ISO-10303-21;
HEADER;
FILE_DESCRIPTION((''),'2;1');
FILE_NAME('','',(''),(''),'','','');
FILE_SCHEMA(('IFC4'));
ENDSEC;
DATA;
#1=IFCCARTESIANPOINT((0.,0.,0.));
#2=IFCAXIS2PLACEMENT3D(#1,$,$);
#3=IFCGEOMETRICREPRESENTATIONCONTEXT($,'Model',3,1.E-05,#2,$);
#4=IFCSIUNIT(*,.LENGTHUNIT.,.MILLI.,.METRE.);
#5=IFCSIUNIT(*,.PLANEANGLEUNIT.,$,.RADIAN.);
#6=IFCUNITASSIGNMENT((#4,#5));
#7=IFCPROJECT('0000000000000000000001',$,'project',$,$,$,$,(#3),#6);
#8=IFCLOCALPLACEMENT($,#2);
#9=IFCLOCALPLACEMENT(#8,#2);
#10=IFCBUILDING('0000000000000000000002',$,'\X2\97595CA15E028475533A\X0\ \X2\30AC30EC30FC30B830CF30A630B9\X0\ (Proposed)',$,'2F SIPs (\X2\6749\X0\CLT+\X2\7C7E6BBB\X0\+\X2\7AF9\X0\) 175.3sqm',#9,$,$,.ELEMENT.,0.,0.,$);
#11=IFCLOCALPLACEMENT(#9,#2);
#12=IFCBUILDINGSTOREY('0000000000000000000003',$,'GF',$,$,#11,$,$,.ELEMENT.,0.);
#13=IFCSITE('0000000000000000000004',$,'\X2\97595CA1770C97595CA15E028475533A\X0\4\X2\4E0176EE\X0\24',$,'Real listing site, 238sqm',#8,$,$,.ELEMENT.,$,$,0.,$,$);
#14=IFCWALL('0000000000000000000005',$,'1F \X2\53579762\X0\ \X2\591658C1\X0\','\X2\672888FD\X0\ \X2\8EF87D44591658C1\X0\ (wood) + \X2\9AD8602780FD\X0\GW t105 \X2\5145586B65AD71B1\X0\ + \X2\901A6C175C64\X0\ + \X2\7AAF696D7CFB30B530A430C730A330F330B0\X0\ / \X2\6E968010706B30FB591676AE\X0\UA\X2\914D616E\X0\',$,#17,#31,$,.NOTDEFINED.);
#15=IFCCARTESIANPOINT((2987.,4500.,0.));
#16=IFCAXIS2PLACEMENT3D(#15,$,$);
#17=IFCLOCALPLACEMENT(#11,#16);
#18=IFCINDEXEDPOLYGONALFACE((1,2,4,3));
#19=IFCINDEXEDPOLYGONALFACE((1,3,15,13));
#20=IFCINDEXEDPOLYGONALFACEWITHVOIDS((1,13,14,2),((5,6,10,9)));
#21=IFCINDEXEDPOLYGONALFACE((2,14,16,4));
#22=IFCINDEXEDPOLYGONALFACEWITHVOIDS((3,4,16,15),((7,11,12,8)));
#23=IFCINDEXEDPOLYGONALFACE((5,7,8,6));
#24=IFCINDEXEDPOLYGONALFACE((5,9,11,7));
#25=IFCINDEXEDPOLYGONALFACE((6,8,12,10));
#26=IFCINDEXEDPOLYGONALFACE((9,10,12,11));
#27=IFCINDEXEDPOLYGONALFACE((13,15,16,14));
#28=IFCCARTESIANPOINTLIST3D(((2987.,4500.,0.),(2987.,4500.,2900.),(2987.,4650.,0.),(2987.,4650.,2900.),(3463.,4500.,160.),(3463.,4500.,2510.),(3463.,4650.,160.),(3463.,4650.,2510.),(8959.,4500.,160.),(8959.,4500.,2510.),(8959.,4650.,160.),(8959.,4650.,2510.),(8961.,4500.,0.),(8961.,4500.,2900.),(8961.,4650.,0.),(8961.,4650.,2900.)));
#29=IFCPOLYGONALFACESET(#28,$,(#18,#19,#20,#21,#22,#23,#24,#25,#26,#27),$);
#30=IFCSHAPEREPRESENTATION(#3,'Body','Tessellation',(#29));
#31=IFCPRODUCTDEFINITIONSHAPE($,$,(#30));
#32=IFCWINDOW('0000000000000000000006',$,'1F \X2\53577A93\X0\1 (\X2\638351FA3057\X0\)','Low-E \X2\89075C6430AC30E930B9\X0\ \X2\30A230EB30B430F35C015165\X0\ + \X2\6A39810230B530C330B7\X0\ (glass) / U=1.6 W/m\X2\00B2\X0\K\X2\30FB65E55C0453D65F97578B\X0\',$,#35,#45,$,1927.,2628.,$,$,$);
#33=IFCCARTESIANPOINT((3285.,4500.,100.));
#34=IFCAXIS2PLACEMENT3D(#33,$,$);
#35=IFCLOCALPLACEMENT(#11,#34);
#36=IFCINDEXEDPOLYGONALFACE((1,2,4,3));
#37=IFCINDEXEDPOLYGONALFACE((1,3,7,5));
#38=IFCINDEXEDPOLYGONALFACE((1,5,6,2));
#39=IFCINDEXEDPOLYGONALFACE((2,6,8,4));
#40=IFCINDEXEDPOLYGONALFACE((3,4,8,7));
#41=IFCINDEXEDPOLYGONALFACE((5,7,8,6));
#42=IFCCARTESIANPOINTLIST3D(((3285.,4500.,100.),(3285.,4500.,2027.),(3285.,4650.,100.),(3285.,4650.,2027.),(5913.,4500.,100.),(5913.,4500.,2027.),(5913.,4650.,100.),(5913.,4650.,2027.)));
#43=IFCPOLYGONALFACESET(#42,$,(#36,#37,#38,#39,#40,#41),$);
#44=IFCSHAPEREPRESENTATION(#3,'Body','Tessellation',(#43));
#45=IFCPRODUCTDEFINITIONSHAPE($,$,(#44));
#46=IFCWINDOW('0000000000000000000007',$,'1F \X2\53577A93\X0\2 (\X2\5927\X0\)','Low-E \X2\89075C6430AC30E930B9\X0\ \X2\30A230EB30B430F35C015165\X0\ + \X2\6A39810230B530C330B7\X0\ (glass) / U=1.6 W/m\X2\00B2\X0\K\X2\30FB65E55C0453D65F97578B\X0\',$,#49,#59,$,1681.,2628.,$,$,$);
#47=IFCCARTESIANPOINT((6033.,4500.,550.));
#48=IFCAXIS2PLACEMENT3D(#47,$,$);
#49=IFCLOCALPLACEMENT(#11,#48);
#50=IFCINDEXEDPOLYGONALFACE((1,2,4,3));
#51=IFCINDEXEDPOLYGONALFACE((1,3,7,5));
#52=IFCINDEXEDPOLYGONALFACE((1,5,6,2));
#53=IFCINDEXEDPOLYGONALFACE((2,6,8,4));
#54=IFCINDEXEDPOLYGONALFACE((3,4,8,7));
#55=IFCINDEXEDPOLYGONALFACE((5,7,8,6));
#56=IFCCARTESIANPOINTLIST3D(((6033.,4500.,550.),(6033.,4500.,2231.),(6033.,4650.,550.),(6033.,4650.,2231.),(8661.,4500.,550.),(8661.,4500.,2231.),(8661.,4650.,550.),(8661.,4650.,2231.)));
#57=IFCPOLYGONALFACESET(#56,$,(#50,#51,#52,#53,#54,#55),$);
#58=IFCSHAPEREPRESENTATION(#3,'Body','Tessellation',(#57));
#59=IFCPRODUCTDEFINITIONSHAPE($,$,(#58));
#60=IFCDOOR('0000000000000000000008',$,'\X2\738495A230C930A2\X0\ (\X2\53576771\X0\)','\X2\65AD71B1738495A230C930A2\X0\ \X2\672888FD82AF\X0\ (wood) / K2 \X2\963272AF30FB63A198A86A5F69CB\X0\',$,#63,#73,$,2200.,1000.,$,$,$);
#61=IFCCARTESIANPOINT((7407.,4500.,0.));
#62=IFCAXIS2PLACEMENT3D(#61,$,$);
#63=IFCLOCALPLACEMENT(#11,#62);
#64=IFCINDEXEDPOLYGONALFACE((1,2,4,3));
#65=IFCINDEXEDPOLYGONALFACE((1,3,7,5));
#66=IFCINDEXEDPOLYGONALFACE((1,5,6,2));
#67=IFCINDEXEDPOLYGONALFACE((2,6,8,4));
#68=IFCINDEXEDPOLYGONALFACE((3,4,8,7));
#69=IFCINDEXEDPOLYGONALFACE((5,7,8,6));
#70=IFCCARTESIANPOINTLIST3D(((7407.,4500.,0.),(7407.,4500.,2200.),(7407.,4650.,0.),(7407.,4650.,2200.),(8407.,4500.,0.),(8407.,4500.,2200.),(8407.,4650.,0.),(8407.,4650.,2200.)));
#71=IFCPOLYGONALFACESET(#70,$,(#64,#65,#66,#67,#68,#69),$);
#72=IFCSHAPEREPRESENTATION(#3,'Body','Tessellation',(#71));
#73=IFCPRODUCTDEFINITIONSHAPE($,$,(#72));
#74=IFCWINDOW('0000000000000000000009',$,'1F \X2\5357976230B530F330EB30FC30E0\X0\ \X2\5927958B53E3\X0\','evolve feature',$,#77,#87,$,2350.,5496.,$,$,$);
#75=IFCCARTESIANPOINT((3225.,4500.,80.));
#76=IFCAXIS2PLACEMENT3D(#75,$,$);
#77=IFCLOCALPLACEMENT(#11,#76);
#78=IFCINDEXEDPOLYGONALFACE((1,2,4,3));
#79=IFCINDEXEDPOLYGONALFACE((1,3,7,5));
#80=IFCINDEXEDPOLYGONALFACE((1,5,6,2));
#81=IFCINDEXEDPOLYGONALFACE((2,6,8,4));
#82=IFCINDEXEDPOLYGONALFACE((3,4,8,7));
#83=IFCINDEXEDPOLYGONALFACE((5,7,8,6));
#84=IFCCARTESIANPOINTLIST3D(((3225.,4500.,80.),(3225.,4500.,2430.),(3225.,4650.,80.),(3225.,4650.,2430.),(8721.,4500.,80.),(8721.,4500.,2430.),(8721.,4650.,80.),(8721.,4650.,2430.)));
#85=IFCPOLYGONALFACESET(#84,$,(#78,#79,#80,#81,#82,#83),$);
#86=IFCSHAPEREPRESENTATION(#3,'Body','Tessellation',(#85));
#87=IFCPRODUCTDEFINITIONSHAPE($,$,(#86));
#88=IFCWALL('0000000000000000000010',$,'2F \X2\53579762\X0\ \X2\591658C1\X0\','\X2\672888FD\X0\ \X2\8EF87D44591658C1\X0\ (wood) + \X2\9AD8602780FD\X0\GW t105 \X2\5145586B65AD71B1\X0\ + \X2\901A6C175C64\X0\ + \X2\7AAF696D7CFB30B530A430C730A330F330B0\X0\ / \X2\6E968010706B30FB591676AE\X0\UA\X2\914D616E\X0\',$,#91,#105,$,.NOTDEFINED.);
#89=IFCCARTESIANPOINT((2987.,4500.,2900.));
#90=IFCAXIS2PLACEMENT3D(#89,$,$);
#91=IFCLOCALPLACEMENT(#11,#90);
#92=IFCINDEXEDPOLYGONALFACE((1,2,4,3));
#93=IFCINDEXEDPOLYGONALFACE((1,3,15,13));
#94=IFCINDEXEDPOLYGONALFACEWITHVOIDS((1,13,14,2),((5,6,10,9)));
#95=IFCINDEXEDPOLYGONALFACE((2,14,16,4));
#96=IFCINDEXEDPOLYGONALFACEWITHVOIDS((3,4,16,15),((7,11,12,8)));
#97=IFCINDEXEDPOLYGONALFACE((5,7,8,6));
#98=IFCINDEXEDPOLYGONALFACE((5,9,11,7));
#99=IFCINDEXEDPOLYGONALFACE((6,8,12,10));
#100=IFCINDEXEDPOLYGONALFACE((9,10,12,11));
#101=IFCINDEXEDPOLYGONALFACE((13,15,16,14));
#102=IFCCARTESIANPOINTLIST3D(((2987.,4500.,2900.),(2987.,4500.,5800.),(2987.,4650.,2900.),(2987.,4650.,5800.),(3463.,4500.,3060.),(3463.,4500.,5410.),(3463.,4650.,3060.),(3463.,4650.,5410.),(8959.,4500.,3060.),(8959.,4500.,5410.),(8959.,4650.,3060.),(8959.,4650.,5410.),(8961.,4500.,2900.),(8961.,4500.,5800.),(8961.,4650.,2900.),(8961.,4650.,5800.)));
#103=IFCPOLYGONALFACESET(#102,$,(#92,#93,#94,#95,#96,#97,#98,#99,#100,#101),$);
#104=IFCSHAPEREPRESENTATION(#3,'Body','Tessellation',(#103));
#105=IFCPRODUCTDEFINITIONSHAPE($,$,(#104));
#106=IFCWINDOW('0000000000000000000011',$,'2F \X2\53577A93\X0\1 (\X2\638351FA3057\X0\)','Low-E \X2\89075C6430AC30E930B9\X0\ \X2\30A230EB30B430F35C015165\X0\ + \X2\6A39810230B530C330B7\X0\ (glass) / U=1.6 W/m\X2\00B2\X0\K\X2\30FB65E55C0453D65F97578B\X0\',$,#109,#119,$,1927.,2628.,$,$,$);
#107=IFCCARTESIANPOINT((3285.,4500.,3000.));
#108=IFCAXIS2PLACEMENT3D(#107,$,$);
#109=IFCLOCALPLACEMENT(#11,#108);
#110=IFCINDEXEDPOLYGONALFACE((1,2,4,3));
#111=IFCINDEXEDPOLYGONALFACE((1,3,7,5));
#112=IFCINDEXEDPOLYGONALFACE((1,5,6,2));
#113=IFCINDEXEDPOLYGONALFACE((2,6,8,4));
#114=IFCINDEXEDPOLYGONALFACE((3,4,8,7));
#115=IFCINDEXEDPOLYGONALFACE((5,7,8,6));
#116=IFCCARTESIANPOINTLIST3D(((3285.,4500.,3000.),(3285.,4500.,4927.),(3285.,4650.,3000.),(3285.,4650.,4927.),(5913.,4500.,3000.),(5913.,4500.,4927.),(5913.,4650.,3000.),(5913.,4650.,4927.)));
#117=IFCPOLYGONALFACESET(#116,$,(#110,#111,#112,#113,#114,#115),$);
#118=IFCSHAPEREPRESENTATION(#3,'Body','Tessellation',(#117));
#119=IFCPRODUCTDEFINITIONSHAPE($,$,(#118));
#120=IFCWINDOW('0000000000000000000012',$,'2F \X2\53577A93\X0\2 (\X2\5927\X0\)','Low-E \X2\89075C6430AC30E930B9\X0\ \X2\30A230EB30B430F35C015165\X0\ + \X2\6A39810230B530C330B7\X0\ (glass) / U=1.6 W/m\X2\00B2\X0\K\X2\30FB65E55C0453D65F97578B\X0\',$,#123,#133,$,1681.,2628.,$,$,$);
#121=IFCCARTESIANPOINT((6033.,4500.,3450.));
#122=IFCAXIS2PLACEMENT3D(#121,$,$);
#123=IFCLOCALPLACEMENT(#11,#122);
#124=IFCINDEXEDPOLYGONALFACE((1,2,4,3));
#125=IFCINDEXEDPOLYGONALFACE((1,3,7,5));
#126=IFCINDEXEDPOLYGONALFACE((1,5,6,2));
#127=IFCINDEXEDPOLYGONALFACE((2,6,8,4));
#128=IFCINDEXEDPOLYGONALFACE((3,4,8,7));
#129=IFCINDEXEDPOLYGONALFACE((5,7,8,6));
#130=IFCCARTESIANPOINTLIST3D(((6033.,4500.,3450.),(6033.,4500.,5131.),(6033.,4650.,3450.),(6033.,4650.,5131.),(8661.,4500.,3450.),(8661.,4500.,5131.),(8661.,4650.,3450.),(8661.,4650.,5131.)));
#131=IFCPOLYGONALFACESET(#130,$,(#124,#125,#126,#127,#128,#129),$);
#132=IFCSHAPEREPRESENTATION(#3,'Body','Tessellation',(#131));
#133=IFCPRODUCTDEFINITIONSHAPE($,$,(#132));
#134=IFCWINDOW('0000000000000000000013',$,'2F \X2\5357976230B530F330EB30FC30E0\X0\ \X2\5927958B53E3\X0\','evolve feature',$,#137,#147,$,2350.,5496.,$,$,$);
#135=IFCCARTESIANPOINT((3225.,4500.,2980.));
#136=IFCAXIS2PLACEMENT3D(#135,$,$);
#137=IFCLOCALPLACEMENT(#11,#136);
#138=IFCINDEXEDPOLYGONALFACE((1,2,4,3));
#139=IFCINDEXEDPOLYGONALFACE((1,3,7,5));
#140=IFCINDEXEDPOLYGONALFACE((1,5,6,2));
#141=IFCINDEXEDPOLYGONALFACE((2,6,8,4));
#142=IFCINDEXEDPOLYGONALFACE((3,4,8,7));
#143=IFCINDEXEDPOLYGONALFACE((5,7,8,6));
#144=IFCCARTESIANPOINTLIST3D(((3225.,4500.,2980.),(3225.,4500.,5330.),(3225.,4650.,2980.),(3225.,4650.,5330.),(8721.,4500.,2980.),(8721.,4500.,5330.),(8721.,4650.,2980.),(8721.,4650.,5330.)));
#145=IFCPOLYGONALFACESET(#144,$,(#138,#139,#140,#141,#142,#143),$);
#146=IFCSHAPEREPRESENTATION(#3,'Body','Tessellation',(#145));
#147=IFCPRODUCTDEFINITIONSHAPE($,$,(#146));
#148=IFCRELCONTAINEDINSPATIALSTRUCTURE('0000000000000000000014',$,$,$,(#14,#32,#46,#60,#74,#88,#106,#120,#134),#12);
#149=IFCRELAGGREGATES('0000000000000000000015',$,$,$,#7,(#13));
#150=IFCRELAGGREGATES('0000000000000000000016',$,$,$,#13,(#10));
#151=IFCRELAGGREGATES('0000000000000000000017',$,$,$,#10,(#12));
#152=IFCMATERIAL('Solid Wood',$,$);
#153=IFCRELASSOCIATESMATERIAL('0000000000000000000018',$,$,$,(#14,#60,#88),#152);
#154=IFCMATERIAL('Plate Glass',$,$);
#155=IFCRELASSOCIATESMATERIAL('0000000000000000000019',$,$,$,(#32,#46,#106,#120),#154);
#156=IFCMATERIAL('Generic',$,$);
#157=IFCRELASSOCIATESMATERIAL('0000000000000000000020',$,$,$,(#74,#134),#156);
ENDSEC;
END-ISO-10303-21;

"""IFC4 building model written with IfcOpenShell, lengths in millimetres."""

from ifc_helpers import new_model, si_unit, frame, frame_2d, origin, place, context, project, spatial, rectangle, extrude, material, element, fill, save


model = new_model("IFC4")

# Units and contexts
model_context = context("Model", 3, precision=1e-05, world=origin())
ifc_project = project(units=[si_unit("LENGTHUNIT", "METRE", prefix="MILLI"), si_unit("PLANEANGLEUNIT", "RADIAN")], contexts=[model_context])

# Site, building, storey
site_placement = place(None, origin())
site = spatial("IfcSite", under=ifc_project, at=site_placement, Name="静岡県静岡市葵区4丁目24", ObjectType="Real listing site, 238sqm", CompositionType="ELEMENT", RefElevation=0.0)
building_placement = place(site_placement, origin())
building = spatial("IfcBuilding", under=site, at=building_placement, Name="静岡市葵区 ガレージハウス (Proposed)", ObjectType="2F SIPs (杉CLT+籾殻+竹) 175.3sqm", CompositionType="ELEMENT", ElevationOfRefHeight=0.0, ElevationOfTerrain=0.0)
storey_placement = place(building_placement, origin())
storey = spatial("IfcBuildingStorey", under=building, at=storey_placement, Name="GF", CompositionType="ELEMENT", Elevation=0.0)

# Shared definitions
ifc_material_1 = material(Name="Solid Wood")
ifc_material_2 = material(Name="Generic")

# Wall, openings, windows, door
wall_1_placement = place(storey_placement, frame((2987.0, 4500.0, 0.0)))
wall_1 = element("IfcWall", 1, at=wall_1_placement, inside=storey, material=ifc_material_1, Name="1F 南面 外壁", Description="木製 軸組外壁 (wood) + 高性能GW t105 充填断熱 + 通気層 + 窯業系サイディング / 準耐火・外皮UA配慮", PredefinedType="NOTDEFINED", context=model_context, shape_type="SweptSolid", body=[
    extrude(rectangle(XDim=5974.0, YDim=150.0, at=frame_2d((2987.0, 75.0))), frame((2987.0, 4500.0, 0.0)), (0.0, 0.0, 1.0), 2900.0),
])
opening_1_placement = place(storey_placement, frame((3285.0, 4500.0, 100.0)))
opening_1 = element("IfcOpeningElement", 2, at=opening_1_placement, cuts=wall_1, PredefinedType="NOTDEFINED", context=model_context, shape_type="SweptSolid", body=[
    extrude(rectangle(XDim=2628.0, YDim=150.0, at=frame_2d((1314.0, 75.0))), frame((3285.0, 4500.0, 100.0)), (0.0, 0.0, 1.0), 1927.0),
])
opening_2_placement = place(storey_placement, frame((6033.0, 4500.0, 550.0)))
opening_2 = element("IfcOpeningElement", 3, at=opening_2_placement, cuts=wall_1, PredefinedType="NOTDEFINED", context=model_context, shape_type="SweptSolid", body=[
    extrude(rectangle(XDim=2628.0, YDim=150.0, at=frame_2d((1314.0, 75.0))), frame((6033.0, 4500.0, 550.0)), (0.0, 0.0, 1.0), 1681.0),
])
opening_3_placement = place(storey_placement, frame((7407.0, 4500.0, 0.0)))
opening_3 = element("IfcOpeningElement", 4, at=opening_3_placement, cuts=wall_1, PredefinedType="NOTDEFINED", context=model_context, shape_type="SweptSolid", body=[
    extrude(rectangle(XDim=1000.0, YDim=150.0, at=frame_2d((500.0, 75.0))), frame((7407.0, 4500.0, 0.0)), (0.0, 0.0, 1.0), 2200.0),
])
opening_4_placement = place(storey_placement, frame((3225.0, 4500.0, 80.0)))
opening_4 = element("IfcOpeningElement", 5, at=opening_4_placement, cuts=wall_1, PredefinedType="NOTDEFINED", context=model_context, shape_type="SweptSolid", body=[
    extrude(rectangle(XDim=5496.0, YDim=150.0, at=frame_2d((2748.0, 75.0))), frame((3225.0, 4500.0, 80.0)), (0.0, 0.0, 1.0), 2350.0),
])
ifc_material_3 = material(Name="Plate Glass")
window_1_placement = place(storey_placement, frame((3285.0, 4500.0, 100.0)))
window_1 = element("IfcWindow", 6, at=window_1_placement, inside=storey, material=ifc_material_3, Name="1F 南窓1 (掃出し)", Description="Low-E 複層ガラス アルゴン封入 + 樹脂サッシ (glass) / U=1.6 W/m²K・日射取得型", OverallHeight=1927.0, OverallWidth=2628.0, context=model_context, shape_type="SweptSolid", body=[
    extrude(rectangle(XDim=2628.0, YDim=150.0, at=frame_2d((1314.0, 75.0))), frame((3285.0, 4500.0, 100.0)), (0.0, 0.0, 1.0), 1927.0),
])
fill(opening_1, window_1)
window_2_placement = place(storey_placement, frame((6033.0, 4500.0, 550.0)))
window_2 = element("IfcWindow", 7, at=window_2_placement, inside=storey, material=ifc_material_3, Name="1F 南窓2 (大)", Description="Low-E 複層ガラス アルゴン封入 + 樹脂サッシ (glass) / U=1.6 W/m²K・日射取得型", OverallHeight=1681.0, OverallWidth=2628.0, context=model_context, shape_type="SweptSolid", body=[
    extrude(rectangle(XDim=2628.0, YDim=150.0, at=frame_2d((1314.0, 75.0))), frame((6033.0, 4500.0, 550.0)), (0.0, 0.0, 1.0), 1681.0),
])
fill(opening_2, window_2)
door_placement = place(storey_placement, frame((7407.0, 4500.0, 0.0)))
door = element("IfcDoor", 8, at=door_placement, inside=storey, material=ifc_material_1, Name="玄関ドア (南東)", Description="断熱玄関ドア 木製芯 (wood) / K2 防犯・採風機構", OverallHeight=2200.0, OverallWidth=1000.0, context=model_context, shape_type="SweptSolid", body=[
    extrude(rectangle(XDim=1000.0, YDim=150.0, at=frame_2d((500.0, 75.0))), frame((7407.0, 4500.0, 0.0)), (0.0, 0.0, 1.0), 2200.0),
])
fill(opening_3, door)
window_3_placement = place(storey_placement, frame((3225.0, 4500.0, 80.0)))
window_3 = element("IfcWindow", 9, at=window_3_placement, inside=storey, material=ifc_material_2, Name="1F 南面サンルーム 大開口", Description="evolve feature", OverallHeight=2350.0, OverallWidth=5496.0, context=model_context, shape_type="SweptSolid", body=[
    extrude(rectangle(XDim=5496.0, YDim=150.0, at=frame_2d((2748.0, 75.0))), frame((3225.0, 4500.0, 80.0)), (0.0, 0.0, 1.0), 2350.0),
])
fill(opening_4, window_3)

# Wall, openings, windows
wall_2_placement = place(storey_placement, frame((2987.0, 4500.0, 2900.0)))
wall_2 = element("IfcWall", 10, at=wall_2_placement, inside=storey, material=ifc_material_1, Name="2F 南面 外壁", Description="木製 軸組外壁 (wood) + 高性能GW t105 充填断熱 + 通気層 + 窯業系サイディング / 準耐火・外皮UA配慮", PredefinedType="NOTDEFINED", context=model_context, shape_type="SweptSolid", body=[
    extrude(rectangle(XDim=5974.0, YDim=150.0, at=frame_2d((2987.0, 75.0))), frame((2987.0, 4500.0, 2900.0)), (0.0, 0.0, 1.0), 2900.0),
])
opening_5_placement = place(storey_placement, frame((3285.0, 4500.0, 3000.0)))
opening_5 = element("IfcOpeningElement", 11, at=opening_5_placement, cuts=wall_2, PredefinedType="NOTDEFINED", context=model_context, shape_type="SweptSolid", body=[
    extrude(rectangle(XDim=2628.0, YDim=150.0, at=frame_2d((1314.0, 75.0))), frame((3285.0, 4500.0, 3000.0)), (0.0, 0.0, 1.0), 1927.0),
])
opening_6_placement = place(storey_placement, frame((6033.0, 4500.0, 3450.0)))
opening_6 = element("IfcOpeningElement", 12, at=opening_6_placement, cuts=wall_2, PredefinedType="NOTDEFINED", context=model_context, shape_type="SweptSolid", body=[
    extrude(rectangle(XDim=2628.0, YDim=150.0, at=frame_2d((1314.0, 75.0))), frame((6033.0, 4500.0, 3450.0)), (0.0, 0.0, 1.0), 1681.0),
])
opening_7_placement = place(storey_placement, frame((3225.0, 4500.0, 2980.0)))
opening_7 = element("IfcOpeningElement", 13, at=opening_7_placement, cuts=wall_2, PredefinedType="NOTDEFINED", context=model_context, shape_type="SweptSolid", body=[
    extrude(rectangle(XDim=5496.0, YDim=150.0, at=frame_2d((2748.0, 75.0))), frame((3225.0, 4500.0, 2980.0)), (0.0, 0.0, 1.0), 2350.0),
])
window_4_placement = place(storey_placement, frame((3285.0, 4500.0, 3000.0)))
window_4 = element("IfcWindow", 14, at=window_4_placement, inside=storey, material=ifc_material_3, Name="2F 南窓1 (掃出し)", Description="Low-E 複層ガラス アルゴン封入 + 樹脂サッシ (glass) / U=1.6 W/m²K・日射取得型", OverallHeight=1927.0, OverallWidth=2628.0, context=model_context, shape_type="SweptSolid", body=[
    extrude(rectangle(XDim=2628.0, YDim=150.0, at=frame_2d((1314.0, 75.0))), frame((3285.0, 4500.0, 3000.0)), (0.0, 0.0, 1.0), 1927.0),
])
fill(opening_5, window_4)
window_5_placement = place(storey_placement, frame((6033.0, 4500.0, 3450.0)))
window_5 = element("IfcWindow", 15, at=window_5_placement, inside=storey, material=ifc_material_3, Name="2F 南窓2 (大)", Description="Low-E 複層ガラス アルゴン封入 + 樹脂サッシ (glass) / U=1.6 W/m²K・日射取得型", OverallHeight=1681.0, OverallWidth=2628.0, context=model_context, shape_type="SweptSolid", body=[
    extrude(rectangle(XDim=2628.0, YDim=150.0, at=frame_2d((1314.0, 75.0))), frame((6033.0, 4500.0, 3450.0)), (0.0, 0.0, 1.0), 1681.0),
])
fill(opening_6, window_5)
window_6_placement = place(storey_placement, frame((3225.0, 4500.0, 2980.0)))
window_6 = element("IfcWindow", 16, at=window_6_placement, inside=storey, material=ifc_material_2, Name="2F 南面サンルーム 大開口", Description="evolve feature", OverallHeight=2350.0, OverallWidth=5496.0, context=model_context, shape_type="SweptSolid", body=[
    extrude(rectangle(XDim=5496.0, YDim=150.0, at=frame_2d((2748.0, 75.0))), frame((3225.0, 4500.0, 2980.0)), (0.0, 0.0, 1.0), 2350.0),
])
fill(opening_7, window_6)

save(model, "model.ifc")
